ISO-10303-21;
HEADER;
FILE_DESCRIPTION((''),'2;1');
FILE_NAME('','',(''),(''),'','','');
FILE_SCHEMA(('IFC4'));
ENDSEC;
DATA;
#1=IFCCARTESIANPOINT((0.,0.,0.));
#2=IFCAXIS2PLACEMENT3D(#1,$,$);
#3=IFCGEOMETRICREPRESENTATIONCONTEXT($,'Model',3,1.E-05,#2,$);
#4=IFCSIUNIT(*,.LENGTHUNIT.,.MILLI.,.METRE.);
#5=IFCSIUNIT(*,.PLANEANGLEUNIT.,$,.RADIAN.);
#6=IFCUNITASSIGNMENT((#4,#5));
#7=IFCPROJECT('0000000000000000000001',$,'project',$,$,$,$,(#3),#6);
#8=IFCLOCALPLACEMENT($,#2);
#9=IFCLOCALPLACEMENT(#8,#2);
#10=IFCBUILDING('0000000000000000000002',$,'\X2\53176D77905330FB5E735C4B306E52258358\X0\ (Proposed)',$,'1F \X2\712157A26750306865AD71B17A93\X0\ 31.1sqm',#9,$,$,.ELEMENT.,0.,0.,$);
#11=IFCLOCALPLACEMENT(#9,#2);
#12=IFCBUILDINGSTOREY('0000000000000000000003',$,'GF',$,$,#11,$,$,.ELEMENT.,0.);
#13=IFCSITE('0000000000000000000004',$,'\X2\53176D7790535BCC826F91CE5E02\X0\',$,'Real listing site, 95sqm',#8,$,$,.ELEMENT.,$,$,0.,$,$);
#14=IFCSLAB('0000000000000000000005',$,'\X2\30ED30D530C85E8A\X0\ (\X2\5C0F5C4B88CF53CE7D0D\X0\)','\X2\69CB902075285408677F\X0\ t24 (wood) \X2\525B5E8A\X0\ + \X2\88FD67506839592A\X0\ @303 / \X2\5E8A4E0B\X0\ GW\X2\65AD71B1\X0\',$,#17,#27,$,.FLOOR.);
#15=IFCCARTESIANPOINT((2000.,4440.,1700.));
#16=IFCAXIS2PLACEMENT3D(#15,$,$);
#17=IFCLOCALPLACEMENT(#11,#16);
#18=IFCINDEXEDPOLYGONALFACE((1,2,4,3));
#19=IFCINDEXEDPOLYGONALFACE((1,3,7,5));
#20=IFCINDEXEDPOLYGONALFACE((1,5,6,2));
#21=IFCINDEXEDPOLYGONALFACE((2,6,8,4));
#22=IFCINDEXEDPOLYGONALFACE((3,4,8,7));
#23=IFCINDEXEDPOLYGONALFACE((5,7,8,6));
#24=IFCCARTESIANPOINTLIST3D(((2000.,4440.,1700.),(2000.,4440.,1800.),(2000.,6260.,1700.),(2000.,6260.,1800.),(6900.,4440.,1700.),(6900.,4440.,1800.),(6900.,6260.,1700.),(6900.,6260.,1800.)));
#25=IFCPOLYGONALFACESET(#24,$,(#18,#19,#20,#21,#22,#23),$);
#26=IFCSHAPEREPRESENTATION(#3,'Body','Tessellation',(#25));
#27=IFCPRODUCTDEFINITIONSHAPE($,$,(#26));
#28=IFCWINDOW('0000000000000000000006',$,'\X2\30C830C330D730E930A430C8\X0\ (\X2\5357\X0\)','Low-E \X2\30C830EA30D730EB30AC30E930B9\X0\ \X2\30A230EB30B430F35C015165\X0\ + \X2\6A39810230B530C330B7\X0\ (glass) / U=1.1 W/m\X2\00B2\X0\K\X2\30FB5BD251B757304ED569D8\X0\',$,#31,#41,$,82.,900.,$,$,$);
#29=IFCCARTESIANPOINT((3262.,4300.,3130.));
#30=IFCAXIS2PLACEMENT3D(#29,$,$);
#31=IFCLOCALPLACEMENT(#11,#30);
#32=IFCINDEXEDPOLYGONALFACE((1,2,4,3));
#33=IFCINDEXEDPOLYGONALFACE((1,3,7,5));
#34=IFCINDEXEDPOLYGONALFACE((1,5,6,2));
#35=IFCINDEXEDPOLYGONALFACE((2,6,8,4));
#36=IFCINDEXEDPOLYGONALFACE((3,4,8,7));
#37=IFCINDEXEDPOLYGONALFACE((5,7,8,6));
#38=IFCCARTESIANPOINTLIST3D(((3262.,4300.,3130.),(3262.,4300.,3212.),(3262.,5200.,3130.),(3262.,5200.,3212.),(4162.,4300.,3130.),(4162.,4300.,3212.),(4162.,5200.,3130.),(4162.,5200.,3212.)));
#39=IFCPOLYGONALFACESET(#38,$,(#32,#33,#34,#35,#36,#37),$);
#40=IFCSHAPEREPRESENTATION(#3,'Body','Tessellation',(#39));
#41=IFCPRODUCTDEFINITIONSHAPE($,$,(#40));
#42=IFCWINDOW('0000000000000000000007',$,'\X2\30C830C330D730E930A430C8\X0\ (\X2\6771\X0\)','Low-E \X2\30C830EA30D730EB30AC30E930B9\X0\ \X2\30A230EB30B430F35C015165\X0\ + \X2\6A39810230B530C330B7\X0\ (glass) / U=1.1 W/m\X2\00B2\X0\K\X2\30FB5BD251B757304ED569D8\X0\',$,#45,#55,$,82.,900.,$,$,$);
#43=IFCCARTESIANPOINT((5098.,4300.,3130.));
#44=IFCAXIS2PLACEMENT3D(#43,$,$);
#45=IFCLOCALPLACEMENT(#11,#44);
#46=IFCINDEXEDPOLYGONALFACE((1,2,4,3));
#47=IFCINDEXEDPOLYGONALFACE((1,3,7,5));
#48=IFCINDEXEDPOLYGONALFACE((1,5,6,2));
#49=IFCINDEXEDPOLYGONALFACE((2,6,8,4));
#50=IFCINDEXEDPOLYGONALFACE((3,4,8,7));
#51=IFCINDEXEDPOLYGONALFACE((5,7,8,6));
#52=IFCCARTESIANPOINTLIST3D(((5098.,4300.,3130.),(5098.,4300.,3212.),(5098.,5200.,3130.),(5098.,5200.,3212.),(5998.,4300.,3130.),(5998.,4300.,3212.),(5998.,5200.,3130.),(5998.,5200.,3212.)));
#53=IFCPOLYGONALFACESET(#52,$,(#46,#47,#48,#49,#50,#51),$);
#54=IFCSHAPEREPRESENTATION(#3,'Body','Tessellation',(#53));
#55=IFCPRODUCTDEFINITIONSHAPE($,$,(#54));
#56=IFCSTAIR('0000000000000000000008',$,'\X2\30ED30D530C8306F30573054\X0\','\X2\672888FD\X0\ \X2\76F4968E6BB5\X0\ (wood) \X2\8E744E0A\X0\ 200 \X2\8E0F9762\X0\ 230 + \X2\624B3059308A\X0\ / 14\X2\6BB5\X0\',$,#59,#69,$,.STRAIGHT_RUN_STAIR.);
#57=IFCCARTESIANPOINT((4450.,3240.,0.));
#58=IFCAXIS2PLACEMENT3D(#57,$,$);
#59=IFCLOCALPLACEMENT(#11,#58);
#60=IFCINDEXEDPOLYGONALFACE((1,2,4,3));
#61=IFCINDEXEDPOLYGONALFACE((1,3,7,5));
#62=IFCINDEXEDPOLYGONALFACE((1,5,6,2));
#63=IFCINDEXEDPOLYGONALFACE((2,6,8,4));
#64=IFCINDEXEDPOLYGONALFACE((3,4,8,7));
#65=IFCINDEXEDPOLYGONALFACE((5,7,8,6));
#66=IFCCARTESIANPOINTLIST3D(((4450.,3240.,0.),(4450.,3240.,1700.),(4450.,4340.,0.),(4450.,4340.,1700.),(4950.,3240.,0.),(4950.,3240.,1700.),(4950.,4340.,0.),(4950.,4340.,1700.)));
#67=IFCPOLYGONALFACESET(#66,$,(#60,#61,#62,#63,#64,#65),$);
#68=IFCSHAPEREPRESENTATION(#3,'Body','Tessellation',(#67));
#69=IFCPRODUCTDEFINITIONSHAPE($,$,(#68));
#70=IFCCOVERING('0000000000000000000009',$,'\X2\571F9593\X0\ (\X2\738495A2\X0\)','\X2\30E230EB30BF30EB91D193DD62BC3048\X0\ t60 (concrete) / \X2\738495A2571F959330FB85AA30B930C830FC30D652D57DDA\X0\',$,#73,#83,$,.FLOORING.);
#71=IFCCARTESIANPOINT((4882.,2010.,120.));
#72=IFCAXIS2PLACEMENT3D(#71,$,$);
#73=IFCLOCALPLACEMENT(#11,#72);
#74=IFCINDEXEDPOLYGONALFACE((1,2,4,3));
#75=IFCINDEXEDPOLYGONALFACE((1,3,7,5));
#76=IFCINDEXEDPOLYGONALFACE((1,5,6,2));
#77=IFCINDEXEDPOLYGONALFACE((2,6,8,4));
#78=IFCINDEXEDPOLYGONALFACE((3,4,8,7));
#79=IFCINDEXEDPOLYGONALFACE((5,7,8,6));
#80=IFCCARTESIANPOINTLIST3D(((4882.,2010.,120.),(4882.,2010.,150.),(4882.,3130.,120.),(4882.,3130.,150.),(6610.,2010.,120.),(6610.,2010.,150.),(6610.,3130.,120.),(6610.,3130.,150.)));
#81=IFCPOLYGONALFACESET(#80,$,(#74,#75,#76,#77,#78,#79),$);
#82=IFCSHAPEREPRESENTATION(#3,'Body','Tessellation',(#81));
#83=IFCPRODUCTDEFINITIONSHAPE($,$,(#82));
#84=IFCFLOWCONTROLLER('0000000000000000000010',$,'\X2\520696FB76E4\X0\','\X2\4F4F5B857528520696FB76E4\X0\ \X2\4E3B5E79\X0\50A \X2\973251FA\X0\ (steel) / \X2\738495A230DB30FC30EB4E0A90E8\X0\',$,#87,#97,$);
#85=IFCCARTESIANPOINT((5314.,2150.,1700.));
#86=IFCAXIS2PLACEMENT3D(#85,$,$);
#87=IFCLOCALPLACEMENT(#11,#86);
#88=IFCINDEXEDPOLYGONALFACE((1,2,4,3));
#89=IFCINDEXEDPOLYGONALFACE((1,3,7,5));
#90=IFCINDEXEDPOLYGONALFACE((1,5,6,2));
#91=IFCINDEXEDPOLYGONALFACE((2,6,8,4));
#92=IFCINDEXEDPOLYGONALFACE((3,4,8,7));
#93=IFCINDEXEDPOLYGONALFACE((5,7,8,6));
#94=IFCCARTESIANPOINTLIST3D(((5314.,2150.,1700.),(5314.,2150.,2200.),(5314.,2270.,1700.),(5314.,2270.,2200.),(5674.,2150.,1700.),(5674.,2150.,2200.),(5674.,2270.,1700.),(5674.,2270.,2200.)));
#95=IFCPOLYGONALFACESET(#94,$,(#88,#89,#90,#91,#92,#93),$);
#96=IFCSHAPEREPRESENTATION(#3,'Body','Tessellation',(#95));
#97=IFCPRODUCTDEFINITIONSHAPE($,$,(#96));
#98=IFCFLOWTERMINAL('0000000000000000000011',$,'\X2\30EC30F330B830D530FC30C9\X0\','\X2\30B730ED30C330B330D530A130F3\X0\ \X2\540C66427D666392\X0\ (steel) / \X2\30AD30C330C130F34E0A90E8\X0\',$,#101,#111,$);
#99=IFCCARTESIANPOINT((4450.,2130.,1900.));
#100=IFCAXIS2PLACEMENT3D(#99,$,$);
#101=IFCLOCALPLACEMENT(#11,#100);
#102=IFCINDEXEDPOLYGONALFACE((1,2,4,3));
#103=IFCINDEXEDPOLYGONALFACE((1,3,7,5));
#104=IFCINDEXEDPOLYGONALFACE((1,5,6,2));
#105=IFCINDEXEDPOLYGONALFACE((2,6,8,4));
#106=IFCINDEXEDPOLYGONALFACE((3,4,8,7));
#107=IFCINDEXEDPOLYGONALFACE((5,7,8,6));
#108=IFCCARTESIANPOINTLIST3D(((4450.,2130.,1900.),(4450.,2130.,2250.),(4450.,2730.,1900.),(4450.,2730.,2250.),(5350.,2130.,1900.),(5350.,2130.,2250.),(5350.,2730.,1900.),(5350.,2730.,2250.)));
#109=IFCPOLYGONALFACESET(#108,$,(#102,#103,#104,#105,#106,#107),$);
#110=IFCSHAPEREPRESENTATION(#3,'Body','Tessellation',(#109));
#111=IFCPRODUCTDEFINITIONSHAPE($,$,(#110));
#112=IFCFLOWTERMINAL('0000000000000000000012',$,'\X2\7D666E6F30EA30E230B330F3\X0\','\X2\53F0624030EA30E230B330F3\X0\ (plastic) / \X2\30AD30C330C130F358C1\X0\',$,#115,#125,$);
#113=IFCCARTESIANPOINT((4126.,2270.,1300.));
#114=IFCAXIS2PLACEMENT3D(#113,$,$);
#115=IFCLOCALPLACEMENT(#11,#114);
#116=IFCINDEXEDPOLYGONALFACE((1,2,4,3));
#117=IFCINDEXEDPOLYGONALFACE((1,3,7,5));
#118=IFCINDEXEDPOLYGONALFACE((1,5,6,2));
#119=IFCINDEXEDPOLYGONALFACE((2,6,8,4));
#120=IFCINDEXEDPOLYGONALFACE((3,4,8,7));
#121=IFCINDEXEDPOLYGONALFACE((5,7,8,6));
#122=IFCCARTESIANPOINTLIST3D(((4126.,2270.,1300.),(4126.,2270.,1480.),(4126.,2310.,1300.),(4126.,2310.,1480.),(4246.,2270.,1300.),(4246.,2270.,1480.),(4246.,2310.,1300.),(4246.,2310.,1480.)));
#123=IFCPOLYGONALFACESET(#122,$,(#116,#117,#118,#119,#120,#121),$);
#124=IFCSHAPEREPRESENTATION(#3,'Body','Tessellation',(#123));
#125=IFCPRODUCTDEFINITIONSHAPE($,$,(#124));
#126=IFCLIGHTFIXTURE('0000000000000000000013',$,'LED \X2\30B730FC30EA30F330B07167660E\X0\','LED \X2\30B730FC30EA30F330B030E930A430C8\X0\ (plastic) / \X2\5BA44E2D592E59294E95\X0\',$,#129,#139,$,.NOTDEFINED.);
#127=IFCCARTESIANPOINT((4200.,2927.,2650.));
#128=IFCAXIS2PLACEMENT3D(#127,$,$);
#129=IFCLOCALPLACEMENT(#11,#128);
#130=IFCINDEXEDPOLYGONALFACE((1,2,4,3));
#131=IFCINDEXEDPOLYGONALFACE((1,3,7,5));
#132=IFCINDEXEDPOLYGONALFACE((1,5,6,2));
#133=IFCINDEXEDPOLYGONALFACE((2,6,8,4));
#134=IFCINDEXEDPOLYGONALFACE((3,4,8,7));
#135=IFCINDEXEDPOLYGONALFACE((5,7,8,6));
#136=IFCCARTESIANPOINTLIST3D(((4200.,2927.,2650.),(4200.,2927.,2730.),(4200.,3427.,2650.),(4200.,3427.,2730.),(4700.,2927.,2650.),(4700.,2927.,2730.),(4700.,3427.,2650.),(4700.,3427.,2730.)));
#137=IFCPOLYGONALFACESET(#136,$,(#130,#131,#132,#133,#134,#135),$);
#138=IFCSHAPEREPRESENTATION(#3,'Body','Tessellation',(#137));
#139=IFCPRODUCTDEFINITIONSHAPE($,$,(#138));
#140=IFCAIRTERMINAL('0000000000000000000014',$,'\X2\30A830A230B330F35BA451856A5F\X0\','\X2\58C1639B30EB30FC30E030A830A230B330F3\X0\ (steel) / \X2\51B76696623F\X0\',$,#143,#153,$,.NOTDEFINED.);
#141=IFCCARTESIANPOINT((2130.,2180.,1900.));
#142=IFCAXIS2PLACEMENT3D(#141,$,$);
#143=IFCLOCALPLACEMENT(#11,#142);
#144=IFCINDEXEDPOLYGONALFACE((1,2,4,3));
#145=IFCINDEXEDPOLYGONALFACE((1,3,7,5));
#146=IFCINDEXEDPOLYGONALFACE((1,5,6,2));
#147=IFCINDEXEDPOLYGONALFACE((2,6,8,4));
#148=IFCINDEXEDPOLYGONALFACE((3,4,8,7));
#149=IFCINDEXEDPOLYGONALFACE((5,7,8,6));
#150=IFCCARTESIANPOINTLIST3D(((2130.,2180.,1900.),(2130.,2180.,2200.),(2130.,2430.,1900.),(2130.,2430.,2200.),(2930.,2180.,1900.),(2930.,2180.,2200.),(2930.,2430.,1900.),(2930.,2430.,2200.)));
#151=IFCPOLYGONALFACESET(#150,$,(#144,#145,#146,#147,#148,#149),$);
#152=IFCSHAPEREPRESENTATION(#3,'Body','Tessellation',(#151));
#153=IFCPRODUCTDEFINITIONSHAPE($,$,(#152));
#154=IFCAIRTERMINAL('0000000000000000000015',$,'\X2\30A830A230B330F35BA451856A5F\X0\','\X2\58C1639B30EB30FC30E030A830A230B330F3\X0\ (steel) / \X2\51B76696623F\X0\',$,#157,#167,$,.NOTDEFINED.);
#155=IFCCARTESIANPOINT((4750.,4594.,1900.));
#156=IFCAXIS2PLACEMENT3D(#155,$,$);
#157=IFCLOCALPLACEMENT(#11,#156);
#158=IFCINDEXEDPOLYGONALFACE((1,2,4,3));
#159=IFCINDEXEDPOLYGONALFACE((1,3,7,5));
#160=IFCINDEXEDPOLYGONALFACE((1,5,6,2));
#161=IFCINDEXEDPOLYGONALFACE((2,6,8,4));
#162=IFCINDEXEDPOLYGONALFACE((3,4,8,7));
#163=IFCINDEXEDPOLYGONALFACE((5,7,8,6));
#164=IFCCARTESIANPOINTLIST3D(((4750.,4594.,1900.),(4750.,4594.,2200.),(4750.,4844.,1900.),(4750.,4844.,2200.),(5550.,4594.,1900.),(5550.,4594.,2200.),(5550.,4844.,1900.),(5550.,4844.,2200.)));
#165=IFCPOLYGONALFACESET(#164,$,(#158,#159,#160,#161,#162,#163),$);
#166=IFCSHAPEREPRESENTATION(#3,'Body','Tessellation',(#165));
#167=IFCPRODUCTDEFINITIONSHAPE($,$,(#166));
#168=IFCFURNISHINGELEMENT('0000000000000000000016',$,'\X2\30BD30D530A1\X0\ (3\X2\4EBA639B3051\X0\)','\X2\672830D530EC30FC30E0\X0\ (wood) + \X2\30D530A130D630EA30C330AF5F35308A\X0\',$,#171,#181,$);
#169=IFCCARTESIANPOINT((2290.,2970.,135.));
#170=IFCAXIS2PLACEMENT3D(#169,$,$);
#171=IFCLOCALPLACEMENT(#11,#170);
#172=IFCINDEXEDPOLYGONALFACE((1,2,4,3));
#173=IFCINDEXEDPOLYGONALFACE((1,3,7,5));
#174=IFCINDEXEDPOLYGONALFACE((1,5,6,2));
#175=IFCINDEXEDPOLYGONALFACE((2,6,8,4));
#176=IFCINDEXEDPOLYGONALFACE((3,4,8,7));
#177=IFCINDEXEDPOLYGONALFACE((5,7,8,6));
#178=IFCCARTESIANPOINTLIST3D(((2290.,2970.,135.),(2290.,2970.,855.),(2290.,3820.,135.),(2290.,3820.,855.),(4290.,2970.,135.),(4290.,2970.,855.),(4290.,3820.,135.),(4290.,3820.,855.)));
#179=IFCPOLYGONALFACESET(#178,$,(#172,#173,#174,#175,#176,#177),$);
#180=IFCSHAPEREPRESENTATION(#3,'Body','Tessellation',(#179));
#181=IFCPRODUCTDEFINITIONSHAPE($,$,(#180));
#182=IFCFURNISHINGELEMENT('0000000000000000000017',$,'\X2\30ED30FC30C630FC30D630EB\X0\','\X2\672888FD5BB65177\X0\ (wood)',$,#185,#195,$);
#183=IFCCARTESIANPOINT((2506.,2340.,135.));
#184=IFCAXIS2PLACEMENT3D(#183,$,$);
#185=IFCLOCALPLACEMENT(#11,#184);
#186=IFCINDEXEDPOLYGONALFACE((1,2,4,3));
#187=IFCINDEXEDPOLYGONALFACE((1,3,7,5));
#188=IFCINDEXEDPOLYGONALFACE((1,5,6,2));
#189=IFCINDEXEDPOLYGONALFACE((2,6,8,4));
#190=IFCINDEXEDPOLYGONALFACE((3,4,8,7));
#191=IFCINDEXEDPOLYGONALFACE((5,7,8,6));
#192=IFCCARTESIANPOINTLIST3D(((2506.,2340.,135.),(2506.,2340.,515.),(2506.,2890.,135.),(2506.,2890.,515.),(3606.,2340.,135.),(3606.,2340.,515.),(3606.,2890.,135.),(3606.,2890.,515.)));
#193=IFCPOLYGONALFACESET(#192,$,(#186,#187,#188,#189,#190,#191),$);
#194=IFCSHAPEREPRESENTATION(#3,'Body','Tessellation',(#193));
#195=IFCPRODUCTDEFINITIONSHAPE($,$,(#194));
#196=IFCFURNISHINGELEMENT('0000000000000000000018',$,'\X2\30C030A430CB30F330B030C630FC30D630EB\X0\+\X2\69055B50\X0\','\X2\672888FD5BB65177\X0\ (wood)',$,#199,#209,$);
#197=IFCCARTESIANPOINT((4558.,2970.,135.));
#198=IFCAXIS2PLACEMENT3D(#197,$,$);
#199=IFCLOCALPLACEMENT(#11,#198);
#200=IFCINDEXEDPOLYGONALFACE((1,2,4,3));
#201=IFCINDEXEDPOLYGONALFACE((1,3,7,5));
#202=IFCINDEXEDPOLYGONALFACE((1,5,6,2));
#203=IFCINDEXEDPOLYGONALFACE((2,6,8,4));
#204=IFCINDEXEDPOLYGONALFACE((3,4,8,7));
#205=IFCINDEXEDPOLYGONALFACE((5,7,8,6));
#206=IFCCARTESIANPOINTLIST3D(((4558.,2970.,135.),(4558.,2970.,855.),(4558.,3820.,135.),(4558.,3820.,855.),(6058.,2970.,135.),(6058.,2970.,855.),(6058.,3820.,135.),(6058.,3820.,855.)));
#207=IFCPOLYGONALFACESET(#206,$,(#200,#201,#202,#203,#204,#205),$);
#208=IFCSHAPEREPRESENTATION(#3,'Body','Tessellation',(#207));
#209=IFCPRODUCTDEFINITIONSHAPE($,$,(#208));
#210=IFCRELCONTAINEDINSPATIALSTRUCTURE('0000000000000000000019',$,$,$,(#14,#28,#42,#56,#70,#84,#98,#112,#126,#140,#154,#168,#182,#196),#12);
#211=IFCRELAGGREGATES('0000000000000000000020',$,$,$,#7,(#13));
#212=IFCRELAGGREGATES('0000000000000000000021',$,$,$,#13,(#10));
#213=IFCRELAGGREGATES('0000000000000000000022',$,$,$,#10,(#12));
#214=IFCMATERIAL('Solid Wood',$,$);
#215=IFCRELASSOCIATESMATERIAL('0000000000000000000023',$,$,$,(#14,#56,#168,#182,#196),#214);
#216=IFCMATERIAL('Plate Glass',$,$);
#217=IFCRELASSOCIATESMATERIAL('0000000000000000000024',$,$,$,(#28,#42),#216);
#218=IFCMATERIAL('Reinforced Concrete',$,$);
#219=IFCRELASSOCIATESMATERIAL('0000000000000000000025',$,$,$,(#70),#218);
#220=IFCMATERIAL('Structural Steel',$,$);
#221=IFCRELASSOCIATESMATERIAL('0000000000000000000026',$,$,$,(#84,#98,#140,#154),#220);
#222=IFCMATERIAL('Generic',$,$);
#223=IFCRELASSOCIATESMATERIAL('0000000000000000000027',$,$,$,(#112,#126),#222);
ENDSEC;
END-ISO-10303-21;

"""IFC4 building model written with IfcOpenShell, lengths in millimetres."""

from ifc_helpers import new_model, si_unit, frame, frame_2d, origin, place, context, project, spatial, rectangle, extrude, material, element, save


model = new_model("IFC4")

# Units and contexts
model_context = context("Model", 3, precision=1e-05, world=origin())
ifc_project = project(units=[si_unit("LENGTHUNIT", "METRE", prefix="MILLI"), si_unit("PLANEANGLEUNIT", "RADIAN")], contexts=[model_context])

# Site, building, storey
site_placement = place(None, origin())
site = spatial("IfcSite", under=ifc_project, at=site_placement, Name="北海道富良野市", ObjectType="Real listing site, 95sqm", CompositionType="ELEMENT", RefElevation=0.0)
building_placement = place(site_placement, origin())
building = spatial("IfcBuilding", under=site, at=building_placement, Name="北海道・平屋の別荘 (Proposed)", ObjectType="1F 無垢材と断熱窓 31.1sqm", CompositionType="ELEMENT", ElevationOfRefHeight=0.0, ElevationOfTerrain=0.0)
storey_placement = place(building_placement, origin())
storey = spatial("IfcBuildingStorey", under=building, at=storey_placement, Name="GF", CompositionType="ELEMENT", Elevation=0.0)

# Shared definitions
ifc_material_1 = material(Name="Solid Wood")

# Slab
slab_placement = place(storey_placement, frame((2000.0, 4440.0, 1700.0)))
element("IfcSlab", 1, at=slab_placement, inside=storey, material=ifc_material_1, Name="ロフト床 (小屋裏収納)", Description="構造用合板 t24 (wood) 剛床 + 製材根太 @303 / 床下 GW断熱", PredefinedType="FLOOR", context=model_context, shape_type="SweptSolid", body=[
    extrude(rectangle(XDim=4900.0, YDim=1820.0, at=frame_2d((2450.0, 910.0))), frame((2000.0, 4440.0, 1700.0)), (0.0, 0.0, 1.0), 100.0),
])

# Windows
ifc_material_2 = material(Name="Plate Glass")
window_1_placement = place(storey_placement, frame((3262.0, 4300.0, 3130.0)))
element("IfcWindow", 2, at=window_1_placement, inside=storey, material=ifc_material_2, Name="トップライト (南)", Description="Low-E トリプルガラス アルゴン封入 + 樹脂サッシ (glass) / U=1.1 W/m²K・寒冷地仕様", OverallHeight=82.0, OverallWidth=900.0, context=model_context, shape_type="SweptSolid", body=[
    extrude(rectangle(XDim=900.0, YDim=900.0, at=frame_2d((450.0, 450.0))), frame((3262.0, 4300.0, 3130.0)), (0.0, 0.0, 1.0), 82.0),
])
window_2_placement = place(storey_placement, frame((5098.0, 4300.0, 3130.0)))
element("IfcWindow", 3, at=window_2_placement, inside=storey, material=ifc_material_2, Name="トップライト (東)", Description="Low-E トリプルガラス アルゴン封入 + 樹脂サッシ (glass) / U=1.1 W/m²K・寒冷地仕様", OverallHeight=82.0, OverallWidth=900.0, context=model_context, shape_type="SweptSolid", body=[
    extrude(rectangle(XDim=900.0, YDim=900.0, at=frame_2d((450.0, 450.0))), frame((5098.0, 4300.0, 3130.0)), (0.0, 0.0, 1.0), 82.0),
])

# Stair
stair_placement = place(storey_placement, frame((4450.0, 3240.0, 0.0)))
element("IfcStair", 4, at=stair_placement, inside=storey, material=ifc_material_1, Name="ロフトはしご", Description="木製 直階段 (wood) 蹴上 200 踏面 230 + 手すり / 14段", PredefinedType="STRAIGHT_RUN_STAIR", context=model_context, shape_type="SweptSolid", body=[
    extrude(rectangle(XDim=500.0, YDim=1100.0, at=frame_2d((250.0, 550.0))), frame((4450.0, 3240.0, 0.0)), (0.0, 0.0, 1.0), 1700.0),
])

# Covering
ifc_material_3 = material(Name="Reinforced Concrete")
covering_placement = place(storey_placement, frame((4882.0, 2010.0, 120.0)))
element("IfcCovering", 5, at=covering_placement, inside=storey, material=ifc_material_3, Name="土間 (玄関)", Description="モルタル金鏝押え t60 (concrete) / 玄関土間・薪ストーブ動線", PredefinedType="FLOORING", context=model_context, shape_type="SweptSolid", body=[
    extrude(rectangle(XDim=1728.0, YDim=1120.0, at=frame_2d((864.0, 560.0))), frame((4882.0, 2010.0, 120.0)), (0.0, 0.0, 1.0), 30.0),
])

# Flow controller
ifc_material_4 = material(Name="Structural Steel")
flow_controller_placement = place(storey_placement, frame((5314.0, 2150.0, 1700.0)))
element("IfcFlowController", 6, at=flow_controller_placement, inside=storey, material=ifc_material_4, Name="分電盤", Description="住宅用分電盤 主幹50A 露出 (steel) / 玄関ホール上部", context=model_context, shape_type="SweptSolid", body=[
    extrude(rectangle(XDim=360.0, YDim=120.0, at=frame_2d((180.0, 60.0))), frame((5314.0, 2150.0, 1700.0)), (0.0, 0.0, 1.0), 500.0),
])

# Flow terminals
flow_terminal_1_placement = place(storey_placement, frame((4450.0, 2130.0, 1900.0)))
element("IfcFlowTerminal", 7, at=flow_terminal_1_placement, inside=storey, material=ifc_material_4, Name="レンジフード", Description="シロッコファン 同時給排 (steel) / キッチン上部", context=model_context, shape_type="SweptSolid", body=[
    extrude(rectangle(XDim=900.0, YDim=600.0, at=frame_2d((450.0, 300.0))), frame((4450.0, 2130.0, 1900.0)), (0.0, 0.0, 1.0), 350.0),
])
ifc_material_5 = material(Name="Generic")
flow_terminal_2_placement = place(storey_placement, frame((4126.0, 2270.0, 1300.0)))
element("IfcFlowTerminal", 8, at=flow_terminal_2_placement, inside=storey, material=ifc_material_5, Name="給湯リモコン", Description="台所リモコン (plastic) / キッチン壁", context=model_context, shape_type="SweptSolid", body=[
    extrude(rectangle(XDim=120.0, YDim=40.0, at=frame_2d((60.0, 20.0))), frame((4126.0, 2270.0, 1300.0)), (0.0, 0.0, 1.0), 180.0),
])

# Light fixture
light_fixture_placement = place(storey_placement, frame((4200.0, 2927.0, 2650.0)))
element("IfcLightFixture", 9, at=light_fixture_placement, inside=storey, material=ifc_material_5, Name="LED シーリング照明", Description="LED シーリングライト (plastic) / 室中央天井", PredefinedType="NOTDEFINED", context=model_context, shape_type="SweptSolid", body=[
    extrude(rectangle(XDim=500.0, YDim=500.0, at=frame_2d((250.0, 250.0))), frame((4200.0, 2927.0, 2650.0)), (0.0, 0.0, 1.0), 80.0),
])

# Air terminals
air_terminal_1_placement = place(storey_placement, frame((2130.0, 2180.0, 1900.0)))
element("IfcAirTerminal", 10, at=air_terminal_1_placement, inside=storey, material=ifc_material_4, Name="エアコン室内機", Description="壁掛ルームエアコン (steel) / 冷暖房", PredefinedType="NOTDEFINED", context=model_context, shape_type="SweptSolid", body=[
    extrude(rectangle(XDim=800.0, YDim=250.0, at=frame_2d((400.0, 125.0))), frame((2130.0, 2180.0, 1900.0)), (0.0, 0.0, 1.0), 300.0),
])
air_terminal_2_placement = place(storey_placement, frame((4750.0, 4594.0, 1900.0)))
element("IfcAirTerminal", 11, at=air_terminal_2_placement, inside=storey, material=ifc_material_4, Name="エアコン室内機", Description="壁掛ルームエアコン (steel) / 冷暖房", PredefinedType="NOTDEFINED", context=model_context, shape_type="SweptSolid", body=[
    extrude(rectangle(XDim=800.0, YDim=250.0, at=frame_2d((400.0, 125.0))), frame((4750.0, 4594.0, 1900.0)), (0.0, 0.0, 1.0), 300.0),
])

# Furnishing elements
furnishing_1_placement = place(storey_placement, frame((2290.0, 2970.0, 135.0)))
element("IfcFurnishingElement", 12, at=furnishing_1_placement, inside=storey, material=ifc_material_1, Name="ソファ (3人掛け)", Description="木フレーム (wood) + ファブリック張り", context=model_context, shape_type="SweptSolid", body=[
    extrude(rectangle(XDim=2000.0, YDim=850.0, at=frame_2d((1000.0, 425.0))), frame((2290.0, 2970.0, 135.0)), (0.0, 0.0, 1.0), 720.0),
])
furnishing_2_placement = place(storey_placement, frame((2506.0, 2340.0, 135.0)))
element("IfcFurnishingElement", 13, at=furnishing_2_placement, inside=storey, material=ifc_material_1, Name="ローテーブル", Description="木製家具 (wood)", context=model_context, shape_type="SweptSolid", body=[
    extrude(rectangle(XDim=1100.0, YDim=550.0, at=frame_2d((550.0, 275.0))), frame((2506.0, 2340.0, 135.0)), (0.0, 0.0, 1.0), 380.0),
])
furnishing_3_placement = place(storey_placement, frame((4558.0, 2970.0, 135.0)))
element("IfcFurnishingElement", 14, at=furnishing_3_placement, inside=storey, material=ifc_material_1, Name="ダイニングテーブル+椅子", Description="木製家具 (wood)", context=model_context, shape_type="SweptSolid", body=[
    extrude(rectangle(XDim=1500.0, YDim=850.0, at=frame_2d((750.0, 425.0))), frame((4558.0, 2970.0, 135.0)), (0.0, 0.0, 1.0), 720.0),
])

save(model, "model.ifc")
